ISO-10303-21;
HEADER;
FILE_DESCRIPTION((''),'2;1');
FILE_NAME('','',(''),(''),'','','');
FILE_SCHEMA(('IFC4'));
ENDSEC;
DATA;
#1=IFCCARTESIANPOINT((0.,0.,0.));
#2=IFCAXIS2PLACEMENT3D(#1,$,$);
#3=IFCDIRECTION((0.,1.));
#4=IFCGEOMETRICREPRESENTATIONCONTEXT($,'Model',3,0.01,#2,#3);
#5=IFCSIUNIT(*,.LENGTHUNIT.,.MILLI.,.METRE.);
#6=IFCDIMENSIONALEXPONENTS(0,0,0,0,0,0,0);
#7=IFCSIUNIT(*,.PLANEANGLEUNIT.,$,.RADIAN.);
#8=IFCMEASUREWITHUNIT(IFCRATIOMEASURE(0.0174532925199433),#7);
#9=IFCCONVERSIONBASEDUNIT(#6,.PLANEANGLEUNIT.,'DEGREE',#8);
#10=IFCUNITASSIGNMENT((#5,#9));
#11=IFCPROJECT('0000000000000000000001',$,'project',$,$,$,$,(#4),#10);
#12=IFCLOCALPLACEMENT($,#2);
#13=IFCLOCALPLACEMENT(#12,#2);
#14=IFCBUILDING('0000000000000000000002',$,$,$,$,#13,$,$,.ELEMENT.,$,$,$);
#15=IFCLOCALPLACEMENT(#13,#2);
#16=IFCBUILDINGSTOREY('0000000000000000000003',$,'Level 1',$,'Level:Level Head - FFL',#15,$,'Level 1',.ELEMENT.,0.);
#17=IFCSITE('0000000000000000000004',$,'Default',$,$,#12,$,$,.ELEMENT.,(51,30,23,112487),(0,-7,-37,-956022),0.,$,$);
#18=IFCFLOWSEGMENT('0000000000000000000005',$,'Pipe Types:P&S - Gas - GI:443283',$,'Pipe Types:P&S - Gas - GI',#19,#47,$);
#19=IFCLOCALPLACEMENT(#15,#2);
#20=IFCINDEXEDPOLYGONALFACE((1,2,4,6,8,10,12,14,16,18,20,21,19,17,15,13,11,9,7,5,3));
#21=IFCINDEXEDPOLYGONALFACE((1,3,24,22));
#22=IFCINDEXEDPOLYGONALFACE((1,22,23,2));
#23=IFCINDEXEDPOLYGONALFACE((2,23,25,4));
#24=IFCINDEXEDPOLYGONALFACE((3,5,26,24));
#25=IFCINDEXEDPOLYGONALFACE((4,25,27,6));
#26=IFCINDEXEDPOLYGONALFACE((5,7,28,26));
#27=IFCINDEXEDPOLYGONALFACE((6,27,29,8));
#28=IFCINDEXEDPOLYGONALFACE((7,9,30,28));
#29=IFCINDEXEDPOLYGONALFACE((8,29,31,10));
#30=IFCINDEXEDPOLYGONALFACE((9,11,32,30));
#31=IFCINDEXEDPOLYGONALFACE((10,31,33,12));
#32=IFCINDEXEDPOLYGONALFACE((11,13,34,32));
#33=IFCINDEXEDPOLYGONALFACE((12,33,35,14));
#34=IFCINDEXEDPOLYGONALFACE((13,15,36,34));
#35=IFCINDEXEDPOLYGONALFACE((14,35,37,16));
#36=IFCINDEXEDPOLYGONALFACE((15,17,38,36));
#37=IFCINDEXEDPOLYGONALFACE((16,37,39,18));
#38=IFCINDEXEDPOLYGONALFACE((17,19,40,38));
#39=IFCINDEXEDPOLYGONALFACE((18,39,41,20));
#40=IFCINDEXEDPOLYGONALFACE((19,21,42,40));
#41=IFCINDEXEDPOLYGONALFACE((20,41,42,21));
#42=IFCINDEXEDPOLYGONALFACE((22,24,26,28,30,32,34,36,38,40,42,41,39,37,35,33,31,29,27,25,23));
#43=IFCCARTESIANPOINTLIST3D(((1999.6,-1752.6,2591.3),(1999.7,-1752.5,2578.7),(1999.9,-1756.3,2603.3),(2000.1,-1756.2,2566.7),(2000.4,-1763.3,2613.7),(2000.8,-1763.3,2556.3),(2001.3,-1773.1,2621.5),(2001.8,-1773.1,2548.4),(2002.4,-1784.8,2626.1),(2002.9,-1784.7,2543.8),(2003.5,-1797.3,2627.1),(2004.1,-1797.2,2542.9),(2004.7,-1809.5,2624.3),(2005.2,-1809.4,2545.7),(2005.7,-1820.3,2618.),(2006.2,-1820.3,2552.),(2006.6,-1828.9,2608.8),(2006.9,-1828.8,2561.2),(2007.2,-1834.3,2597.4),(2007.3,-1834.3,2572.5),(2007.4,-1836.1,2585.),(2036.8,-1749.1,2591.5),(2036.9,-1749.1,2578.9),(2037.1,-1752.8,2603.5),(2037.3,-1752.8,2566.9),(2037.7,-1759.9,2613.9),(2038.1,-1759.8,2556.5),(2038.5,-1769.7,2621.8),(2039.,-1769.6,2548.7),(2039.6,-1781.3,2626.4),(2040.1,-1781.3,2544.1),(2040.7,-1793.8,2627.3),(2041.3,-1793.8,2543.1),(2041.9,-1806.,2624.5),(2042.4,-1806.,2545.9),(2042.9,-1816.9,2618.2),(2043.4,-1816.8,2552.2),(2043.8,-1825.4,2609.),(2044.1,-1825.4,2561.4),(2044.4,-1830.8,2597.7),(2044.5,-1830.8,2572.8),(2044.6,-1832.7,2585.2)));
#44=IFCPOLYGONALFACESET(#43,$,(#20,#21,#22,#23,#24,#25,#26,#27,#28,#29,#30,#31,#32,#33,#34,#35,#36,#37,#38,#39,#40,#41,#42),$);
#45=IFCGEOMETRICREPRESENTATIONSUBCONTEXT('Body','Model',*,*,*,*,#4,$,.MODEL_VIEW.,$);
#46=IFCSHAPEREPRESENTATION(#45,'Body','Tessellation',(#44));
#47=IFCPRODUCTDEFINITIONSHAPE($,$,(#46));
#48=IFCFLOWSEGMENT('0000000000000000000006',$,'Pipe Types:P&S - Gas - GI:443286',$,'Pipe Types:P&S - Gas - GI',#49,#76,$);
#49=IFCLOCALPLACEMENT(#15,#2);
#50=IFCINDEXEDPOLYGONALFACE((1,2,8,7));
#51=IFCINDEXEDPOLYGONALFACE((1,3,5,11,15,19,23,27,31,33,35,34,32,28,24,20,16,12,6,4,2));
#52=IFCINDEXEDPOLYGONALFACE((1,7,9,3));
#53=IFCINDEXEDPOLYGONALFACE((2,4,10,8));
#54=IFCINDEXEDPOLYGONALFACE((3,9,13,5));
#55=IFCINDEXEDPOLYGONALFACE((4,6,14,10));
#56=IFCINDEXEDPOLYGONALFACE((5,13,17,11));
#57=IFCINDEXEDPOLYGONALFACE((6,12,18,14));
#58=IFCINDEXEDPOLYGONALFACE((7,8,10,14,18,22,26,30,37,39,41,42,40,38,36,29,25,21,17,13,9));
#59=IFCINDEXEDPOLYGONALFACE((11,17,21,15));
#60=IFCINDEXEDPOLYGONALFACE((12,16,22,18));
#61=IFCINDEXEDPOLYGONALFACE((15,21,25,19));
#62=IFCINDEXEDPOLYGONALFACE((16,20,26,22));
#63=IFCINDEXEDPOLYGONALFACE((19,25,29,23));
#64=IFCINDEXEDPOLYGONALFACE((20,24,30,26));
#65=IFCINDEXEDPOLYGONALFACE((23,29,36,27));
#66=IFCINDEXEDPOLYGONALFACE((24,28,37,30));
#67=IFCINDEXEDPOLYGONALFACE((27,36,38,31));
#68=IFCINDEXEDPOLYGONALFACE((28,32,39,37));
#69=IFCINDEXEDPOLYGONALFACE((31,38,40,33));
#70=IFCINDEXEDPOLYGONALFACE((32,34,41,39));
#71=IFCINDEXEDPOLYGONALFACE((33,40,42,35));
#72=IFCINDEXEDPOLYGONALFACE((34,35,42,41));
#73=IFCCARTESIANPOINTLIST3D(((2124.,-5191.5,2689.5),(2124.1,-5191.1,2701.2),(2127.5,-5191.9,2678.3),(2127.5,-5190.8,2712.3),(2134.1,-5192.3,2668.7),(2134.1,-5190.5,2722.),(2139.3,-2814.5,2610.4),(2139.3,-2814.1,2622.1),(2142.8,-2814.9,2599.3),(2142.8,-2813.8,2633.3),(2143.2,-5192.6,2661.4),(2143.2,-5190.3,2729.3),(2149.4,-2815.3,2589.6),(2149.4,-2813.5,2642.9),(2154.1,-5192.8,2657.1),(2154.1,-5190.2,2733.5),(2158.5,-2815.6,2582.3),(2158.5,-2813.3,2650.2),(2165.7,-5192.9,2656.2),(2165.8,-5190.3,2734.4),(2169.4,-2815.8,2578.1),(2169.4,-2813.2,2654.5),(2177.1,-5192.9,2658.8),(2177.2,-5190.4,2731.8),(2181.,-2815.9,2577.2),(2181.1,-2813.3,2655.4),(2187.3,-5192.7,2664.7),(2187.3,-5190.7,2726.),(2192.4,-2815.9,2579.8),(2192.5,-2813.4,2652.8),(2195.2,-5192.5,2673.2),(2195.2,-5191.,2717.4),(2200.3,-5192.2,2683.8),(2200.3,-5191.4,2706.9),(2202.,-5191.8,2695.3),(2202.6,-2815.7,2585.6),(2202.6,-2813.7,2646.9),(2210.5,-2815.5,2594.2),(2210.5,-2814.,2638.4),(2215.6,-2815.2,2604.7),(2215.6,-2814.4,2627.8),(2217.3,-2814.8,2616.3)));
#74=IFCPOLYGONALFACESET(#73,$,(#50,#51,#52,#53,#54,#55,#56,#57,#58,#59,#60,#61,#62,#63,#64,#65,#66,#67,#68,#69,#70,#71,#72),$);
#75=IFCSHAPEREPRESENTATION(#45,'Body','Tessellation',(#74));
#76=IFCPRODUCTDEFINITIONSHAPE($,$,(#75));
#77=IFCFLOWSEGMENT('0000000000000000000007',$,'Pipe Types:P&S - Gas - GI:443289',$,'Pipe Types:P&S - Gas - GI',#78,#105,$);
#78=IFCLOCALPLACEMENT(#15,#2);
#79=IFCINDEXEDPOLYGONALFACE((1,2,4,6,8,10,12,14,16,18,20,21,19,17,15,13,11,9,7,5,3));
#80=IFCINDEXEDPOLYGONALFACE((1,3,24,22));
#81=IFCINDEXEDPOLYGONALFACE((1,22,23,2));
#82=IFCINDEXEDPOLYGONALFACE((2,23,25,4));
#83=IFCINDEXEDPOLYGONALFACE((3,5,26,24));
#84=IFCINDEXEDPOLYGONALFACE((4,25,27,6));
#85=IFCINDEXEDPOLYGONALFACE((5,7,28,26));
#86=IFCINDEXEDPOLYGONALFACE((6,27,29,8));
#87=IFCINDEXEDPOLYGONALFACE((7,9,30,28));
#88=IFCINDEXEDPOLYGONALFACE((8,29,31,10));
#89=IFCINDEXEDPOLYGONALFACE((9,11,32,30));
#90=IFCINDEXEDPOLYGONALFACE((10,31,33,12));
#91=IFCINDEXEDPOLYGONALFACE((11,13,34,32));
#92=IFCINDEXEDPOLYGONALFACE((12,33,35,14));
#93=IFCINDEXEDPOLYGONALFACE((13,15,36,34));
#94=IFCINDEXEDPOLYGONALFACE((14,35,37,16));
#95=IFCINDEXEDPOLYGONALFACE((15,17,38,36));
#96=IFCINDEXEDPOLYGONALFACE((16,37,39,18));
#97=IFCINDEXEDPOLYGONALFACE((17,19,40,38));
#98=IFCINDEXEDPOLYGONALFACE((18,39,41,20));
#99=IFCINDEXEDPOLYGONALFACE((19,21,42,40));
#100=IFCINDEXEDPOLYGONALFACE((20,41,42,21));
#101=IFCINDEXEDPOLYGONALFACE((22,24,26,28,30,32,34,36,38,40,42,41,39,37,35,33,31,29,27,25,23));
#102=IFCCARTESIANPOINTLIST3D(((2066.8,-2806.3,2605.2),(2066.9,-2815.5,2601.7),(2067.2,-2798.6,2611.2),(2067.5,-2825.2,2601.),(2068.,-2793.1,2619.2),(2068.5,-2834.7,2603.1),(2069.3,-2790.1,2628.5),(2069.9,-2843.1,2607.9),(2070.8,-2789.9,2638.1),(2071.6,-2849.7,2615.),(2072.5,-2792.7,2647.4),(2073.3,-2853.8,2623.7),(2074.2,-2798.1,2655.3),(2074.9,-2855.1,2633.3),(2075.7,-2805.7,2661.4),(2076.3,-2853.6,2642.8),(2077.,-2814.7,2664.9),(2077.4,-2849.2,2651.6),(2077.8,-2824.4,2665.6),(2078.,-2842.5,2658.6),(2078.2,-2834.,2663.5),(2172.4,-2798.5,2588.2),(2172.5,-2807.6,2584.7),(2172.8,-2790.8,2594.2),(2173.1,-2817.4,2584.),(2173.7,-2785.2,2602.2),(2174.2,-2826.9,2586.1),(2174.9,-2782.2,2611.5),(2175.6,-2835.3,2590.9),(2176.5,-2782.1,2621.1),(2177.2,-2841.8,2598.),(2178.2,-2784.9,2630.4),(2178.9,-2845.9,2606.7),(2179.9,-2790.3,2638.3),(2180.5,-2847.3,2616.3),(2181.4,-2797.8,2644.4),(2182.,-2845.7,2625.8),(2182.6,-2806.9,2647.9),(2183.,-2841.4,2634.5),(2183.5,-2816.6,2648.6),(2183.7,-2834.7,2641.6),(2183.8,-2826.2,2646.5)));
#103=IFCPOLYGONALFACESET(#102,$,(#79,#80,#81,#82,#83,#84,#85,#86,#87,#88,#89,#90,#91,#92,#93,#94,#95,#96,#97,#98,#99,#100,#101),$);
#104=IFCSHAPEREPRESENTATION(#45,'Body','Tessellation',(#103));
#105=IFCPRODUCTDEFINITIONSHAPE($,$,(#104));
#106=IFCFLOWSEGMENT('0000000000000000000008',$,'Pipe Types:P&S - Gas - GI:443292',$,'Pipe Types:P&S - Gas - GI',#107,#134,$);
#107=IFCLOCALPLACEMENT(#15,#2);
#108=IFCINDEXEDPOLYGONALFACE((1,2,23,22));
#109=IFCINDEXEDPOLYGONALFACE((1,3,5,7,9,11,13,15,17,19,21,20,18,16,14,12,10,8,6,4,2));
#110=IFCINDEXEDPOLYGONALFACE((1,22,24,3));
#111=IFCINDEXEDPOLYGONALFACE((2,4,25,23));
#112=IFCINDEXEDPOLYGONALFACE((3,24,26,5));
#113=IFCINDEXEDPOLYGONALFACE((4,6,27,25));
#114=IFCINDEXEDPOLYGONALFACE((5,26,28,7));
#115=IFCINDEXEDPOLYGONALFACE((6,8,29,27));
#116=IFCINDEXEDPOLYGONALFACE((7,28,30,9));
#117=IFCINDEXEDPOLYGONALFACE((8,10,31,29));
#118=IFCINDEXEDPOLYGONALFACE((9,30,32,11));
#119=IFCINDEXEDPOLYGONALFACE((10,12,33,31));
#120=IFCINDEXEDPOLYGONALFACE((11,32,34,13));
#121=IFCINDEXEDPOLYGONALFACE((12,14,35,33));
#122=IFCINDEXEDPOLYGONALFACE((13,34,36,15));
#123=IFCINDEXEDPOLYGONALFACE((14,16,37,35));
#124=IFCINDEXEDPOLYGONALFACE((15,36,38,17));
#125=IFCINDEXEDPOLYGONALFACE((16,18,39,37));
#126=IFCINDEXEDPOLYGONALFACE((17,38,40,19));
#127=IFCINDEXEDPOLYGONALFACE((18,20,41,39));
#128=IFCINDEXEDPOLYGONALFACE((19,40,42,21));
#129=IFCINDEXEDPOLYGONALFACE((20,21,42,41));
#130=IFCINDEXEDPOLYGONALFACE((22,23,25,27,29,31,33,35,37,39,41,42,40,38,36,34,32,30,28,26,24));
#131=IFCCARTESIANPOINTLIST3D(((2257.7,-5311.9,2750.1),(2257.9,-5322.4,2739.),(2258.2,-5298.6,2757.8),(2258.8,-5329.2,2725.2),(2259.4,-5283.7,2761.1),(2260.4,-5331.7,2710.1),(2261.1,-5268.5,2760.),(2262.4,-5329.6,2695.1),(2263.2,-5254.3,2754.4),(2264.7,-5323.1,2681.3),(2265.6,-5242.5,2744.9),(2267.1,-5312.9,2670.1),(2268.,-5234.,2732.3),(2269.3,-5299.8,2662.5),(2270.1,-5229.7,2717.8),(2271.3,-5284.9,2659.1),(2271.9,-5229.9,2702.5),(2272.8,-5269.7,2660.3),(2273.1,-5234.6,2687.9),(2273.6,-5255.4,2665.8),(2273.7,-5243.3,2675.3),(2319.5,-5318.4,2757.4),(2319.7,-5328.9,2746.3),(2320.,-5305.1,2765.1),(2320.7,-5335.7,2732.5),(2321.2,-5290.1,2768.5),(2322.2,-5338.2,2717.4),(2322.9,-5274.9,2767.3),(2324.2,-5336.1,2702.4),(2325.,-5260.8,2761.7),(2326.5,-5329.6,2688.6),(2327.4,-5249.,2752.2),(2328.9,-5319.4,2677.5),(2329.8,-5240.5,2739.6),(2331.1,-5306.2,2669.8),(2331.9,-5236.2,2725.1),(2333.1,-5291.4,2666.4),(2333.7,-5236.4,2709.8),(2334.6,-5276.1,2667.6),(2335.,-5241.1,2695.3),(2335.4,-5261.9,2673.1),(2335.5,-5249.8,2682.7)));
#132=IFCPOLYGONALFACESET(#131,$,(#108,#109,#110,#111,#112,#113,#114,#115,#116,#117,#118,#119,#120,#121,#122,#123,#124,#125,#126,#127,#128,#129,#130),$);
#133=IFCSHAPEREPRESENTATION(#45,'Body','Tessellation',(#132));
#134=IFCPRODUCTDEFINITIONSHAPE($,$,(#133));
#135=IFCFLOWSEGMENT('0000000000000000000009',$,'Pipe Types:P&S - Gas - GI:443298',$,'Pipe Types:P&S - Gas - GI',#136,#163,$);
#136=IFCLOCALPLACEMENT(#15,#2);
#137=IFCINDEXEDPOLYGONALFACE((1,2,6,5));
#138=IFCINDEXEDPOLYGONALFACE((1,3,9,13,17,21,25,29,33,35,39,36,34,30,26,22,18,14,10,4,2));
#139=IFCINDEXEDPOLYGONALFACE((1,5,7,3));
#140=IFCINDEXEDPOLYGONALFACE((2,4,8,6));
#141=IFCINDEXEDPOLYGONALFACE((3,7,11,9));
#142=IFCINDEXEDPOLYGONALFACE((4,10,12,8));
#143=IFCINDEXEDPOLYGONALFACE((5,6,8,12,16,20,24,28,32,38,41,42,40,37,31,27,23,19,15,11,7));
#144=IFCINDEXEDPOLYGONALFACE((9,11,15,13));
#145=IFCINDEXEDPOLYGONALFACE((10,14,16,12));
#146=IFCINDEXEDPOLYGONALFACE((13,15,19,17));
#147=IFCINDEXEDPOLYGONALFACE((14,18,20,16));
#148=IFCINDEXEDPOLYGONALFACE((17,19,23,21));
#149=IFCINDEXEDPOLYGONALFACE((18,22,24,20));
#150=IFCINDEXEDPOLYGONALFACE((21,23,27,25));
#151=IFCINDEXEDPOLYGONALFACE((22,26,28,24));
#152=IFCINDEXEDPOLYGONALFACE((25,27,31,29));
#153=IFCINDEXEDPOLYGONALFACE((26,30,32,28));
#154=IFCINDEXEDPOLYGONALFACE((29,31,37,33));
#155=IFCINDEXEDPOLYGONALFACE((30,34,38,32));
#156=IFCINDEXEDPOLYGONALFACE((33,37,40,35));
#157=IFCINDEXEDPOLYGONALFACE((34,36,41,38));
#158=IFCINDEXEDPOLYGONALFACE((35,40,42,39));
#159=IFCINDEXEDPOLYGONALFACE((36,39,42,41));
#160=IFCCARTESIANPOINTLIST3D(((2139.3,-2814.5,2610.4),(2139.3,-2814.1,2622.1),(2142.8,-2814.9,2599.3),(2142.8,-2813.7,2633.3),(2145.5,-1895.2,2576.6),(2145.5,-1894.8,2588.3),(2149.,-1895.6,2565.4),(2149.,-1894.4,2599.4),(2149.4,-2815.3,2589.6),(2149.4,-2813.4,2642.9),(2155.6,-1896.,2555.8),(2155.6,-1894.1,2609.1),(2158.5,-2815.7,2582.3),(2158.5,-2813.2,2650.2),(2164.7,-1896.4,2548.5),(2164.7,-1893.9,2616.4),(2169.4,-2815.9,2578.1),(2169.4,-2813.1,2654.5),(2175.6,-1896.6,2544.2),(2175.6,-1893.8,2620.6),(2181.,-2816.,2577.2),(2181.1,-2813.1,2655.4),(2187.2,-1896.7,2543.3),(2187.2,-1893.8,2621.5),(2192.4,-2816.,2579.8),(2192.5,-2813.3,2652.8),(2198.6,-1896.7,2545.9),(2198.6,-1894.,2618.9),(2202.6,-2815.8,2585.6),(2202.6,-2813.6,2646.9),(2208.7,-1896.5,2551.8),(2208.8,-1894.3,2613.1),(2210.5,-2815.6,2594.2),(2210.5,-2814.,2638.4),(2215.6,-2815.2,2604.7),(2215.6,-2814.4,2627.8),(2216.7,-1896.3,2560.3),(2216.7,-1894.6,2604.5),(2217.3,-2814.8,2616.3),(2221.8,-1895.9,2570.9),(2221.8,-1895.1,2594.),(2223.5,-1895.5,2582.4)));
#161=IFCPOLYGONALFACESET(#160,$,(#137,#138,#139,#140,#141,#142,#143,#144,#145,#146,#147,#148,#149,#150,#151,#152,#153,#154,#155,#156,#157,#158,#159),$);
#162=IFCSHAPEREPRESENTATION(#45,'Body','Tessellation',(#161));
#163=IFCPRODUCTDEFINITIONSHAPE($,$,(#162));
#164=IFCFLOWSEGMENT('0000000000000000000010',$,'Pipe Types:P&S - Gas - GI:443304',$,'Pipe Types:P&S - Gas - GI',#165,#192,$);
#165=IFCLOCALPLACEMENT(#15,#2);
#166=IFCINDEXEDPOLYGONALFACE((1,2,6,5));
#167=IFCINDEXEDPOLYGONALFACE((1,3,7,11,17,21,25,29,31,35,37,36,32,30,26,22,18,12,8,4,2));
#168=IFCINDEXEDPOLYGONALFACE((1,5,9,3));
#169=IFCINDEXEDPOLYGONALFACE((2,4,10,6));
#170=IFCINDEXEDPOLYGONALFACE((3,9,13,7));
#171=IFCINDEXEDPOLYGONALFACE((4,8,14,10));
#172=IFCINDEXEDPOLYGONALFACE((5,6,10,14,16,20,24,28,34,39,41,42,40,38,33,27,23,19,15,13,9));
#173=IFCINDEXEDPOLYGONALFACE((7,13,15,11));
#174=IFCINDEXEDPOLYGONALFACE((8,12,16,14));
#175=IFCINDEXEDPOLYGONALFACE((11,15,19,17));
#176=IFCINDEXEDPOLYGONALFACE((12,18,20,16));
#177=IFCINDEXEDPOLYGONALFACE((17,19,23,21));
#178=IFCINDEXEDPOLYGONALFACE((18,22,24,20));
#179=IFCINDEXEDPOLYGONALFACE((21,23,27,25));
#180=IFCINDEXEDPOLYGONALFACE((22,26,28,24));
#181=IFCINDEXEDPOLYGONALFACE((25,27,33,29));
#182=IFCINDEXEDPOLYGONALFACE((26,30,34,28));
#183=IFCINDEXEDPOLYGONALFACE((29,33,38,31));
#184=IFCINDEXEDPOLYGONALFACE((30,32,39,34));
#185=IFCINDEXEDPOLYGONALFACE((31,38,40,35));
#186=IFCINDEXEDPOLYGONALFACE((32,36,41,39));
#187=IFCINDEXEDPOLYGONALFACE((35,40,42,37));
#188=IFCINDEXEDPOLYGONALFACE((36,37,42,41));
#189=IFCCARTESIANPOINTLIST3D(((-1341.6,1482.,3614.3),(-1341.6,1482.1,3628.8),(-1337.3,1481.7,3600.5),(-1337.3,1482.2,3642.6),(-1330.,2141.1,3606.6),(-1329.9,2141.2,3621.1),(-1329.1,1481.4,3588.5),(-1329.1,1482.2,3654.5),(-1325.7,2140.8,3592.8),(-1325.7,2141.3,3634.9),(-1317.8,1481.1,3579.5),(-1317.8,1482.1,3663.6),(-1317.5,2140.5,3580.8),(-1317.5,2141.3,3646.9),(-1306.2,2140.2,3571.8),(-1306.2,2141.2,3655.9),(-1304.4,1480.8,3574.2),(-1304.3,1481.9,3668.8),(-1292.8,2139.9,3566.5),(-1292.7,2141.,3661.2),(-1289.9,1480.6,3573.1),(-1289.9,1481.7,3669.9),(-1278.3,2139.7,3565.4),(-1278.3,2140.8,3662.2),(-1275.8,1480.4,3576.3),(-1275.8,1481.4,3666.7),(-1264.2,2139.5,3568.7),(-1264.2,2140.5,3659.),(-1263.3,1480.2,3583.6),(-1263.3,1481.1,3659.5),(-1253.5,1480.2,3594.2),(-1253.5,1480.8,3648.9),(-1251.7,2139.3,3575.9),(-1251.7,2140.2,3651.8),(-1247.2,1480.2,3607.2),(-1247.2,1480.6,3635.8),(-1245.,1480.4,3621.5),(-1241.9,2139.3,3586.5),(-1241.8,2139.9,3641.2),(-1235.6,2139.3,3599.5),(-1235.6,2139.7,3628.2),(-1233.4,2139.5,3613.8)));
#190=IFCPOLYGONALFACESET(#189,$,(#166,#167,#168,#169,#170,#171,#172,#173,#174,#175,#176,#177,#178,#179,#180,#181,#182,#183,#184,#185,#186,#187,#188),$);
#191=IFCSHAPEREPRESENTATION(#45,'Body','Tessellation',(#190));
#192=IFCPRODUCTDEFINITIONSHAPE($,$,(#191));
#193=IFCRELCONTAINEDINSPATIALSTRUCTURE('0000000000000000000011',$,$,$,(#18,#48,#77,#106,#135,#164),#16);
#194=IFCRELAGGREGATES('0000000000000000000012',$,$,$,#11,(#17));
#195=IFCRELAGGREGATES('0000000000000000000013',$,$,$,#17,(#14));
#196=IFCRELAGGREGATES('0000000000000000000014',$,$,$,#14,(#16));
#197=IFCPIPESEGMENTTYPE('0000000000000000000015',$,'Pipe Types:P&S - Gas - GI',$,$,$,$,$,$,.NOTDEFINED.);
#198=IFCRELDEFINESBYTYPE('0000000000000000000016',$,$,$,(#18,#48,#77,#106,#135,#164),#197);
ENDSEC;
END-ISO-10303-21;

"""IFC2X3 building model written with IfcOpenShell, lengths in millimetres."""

from ifc_helpers import new_model, entity, si_unit, converted_unit, direction, frame, frame_2d, origin, origin_2d_with_axis, place, context, subcontext, project, spatial, circle, extrude, type_object, element, save


model = new_model("IFC2X3")

# Units and contexts
model_context = context("Model", 3, precision=0.01, world=origin(), true_north=direction((0.0, 1.0)))
body_context = subcontext(model_context, "Body", "Model", "MODEL_VIEW")
ifc_project = project(units=[si_unit("LENGTHUNIT", "METRE", prefix="MILLI"), converted_unit("PLANEANGLEUNIT", "DEGREE", entity("IfcRatioMeasure", 0.0174532925199433), si_unit("PLANEANGLEUNIT", "RADIAN"), dimensions=[0, 0, 0, 0, 0, 0, 0])], contexts=[model_context])

# Site, building, storey
site_placement = place(None, origin())
site = spatial("IfcSite", under=ifc_project, at=site_placement, Name="Default", CompositionType="ELEMENT", RefLatitude=(51, 30, 23, 112487), RefLongitude=(0, -7, -37, -956022), RefElevation=0.0)
building_placement = place(site_placement, origin())
building = spatial("IfcBuilding", under=site, at=building_placement, CompositionType="ELEMENT")
storey_placement = place(building_placement, origin())
storey = spatial("IfcBuildingStorey", under=building, at=storey_placement, Name="Level 1", ObjectType="Level:Level Head - FFL", LongName="Level 1", CompositionType="ELEMENT", Elevation=0.0)

# Flow segments
pipe_segment_type = type_object("IfcPipeSegmentType", Name="Pipe Types:P&S - Gas - GI", PredefinedType="NOTDEFINED")
flow_segment_1_placement = place(storey_placement, origin())
element("IfcFlowSegment", 1, at=flow_segment_1_placement, inside=storey, type_object=pipe_segment_type, Name="Pipe Types:P&S - Gas - GI:443283", ObjectType="Pipe Types:P&S - Gas - GI", context=body_context, shape_type="SweptSolid", body=[
    extrude(circle(Radius=42.2, at=origin_2d_with_axis()), frame((2003.5, -1794.1, 2585.0), z_axis=(0.99569, 0.09249, 0.006865), x_axis=(0.092492, -0.995713, 0.0)), (0.0, 0.0, 1.0), 37.4),
])
flow_segment_2_placement = place(storey_placement, origin())
element("IfcFlowSegment", 2, at=flow_segment_2_placement, inside=storey, type_object=pipe_segment_type, Name="Pipe Types:P&S - Gas - GI:443286", ObjectType="Pipe Types:P&S - Gas - GI", context=body_context, shape_type="SweptSolid", body=[
    extrude(circle(Radius=39.2, at=frame_2d((0.0, 0.0), x_axis=(1.0, 0.0))), frame((2162.8, -5191.6, 2695.3), z_axis=(0.00643, 0.999427, -0.033231), x_axis=(0.999979, -0.006434, 0.0)), (0.0, 0.0, 1.0), 2378.4),
])
flow_segment_3_placement = place(storey_placement, origin())
element("IfcFlowSegment", 3, at=flow_segment_3_placement, inside=storey, type_object=pipe_segment_type, Name="Pipe Types:P&S - Gas - GI:443289", ObjectType="Pipe Types:P&S - Gas - GI", context=body_context, shape_type="SweptSolid", body=[
    extrude(circle(Radius=32.8, at=frame_2d((0.0, 0.0), x_axis=(1.0, 0.0))), frame((2178.1, -2814.6, 2616.3), z_axis=(-0.984662, -0.07299, 0.158474), x_axis=(0.073924, -0.997264, 0.0)), (0.0, 0.0, 1.0), 107.3),
])
flow_segment_4_placement = place(storey_placement, origin())
element("IfcFlowSegment", 4, at=flow_segment_4_placement, inside=storey, type_object=pipe_segment_type, Name="Pipe Types:P&S - Gas - GI:443292", ObjectType="Pipe Types:P&S - Gas - GI", context=body_context, shape_type="SweptSolid", body=[
    extrude(circle(Radius=51.5, at=frame_2d((0.0, 0.0), x_axis=(1.0, 0.0))), frame((2327.5, -5286.9, 2717.4), z_axis=(-0.987779, 0.103283, -0.11673), x_axis=(-0.103994, -0.994578, 0.0)), (0.0, 0.0, 1.0), 62.6),
])
flow_segment_5_placement = place(storey_placement, origin())
element("IfcFlowSegment", 5, at=flow_segment_5_placement, inside=storey, type_object=pipe_segment_type, Name="Pipe Types:P&S - Gas - GI:443298", ObjectType="Pipe Types:P&S - Gas - GI", context=body_context, shape_type="SweptSolid", body=[
    extrude(circle(Radius=39.2, at=frame_2d((0.0, 0.0), x_axis=(1.0, 0.0))), frame((2184.3, -1895.2, 2582.4), z_axis=(-0.006722, -0.9993, 0.036814), x_axis=(0.999977, -0.006727, 0.0)), (0.0, 0.0, 1.0), 920.0),
])
flow_segment_6_placement = place(storey_placement, origin())
element("IfcFlowSegment", 6, at=flow_segment_6_placement, inside=storey, type_object=pipe_segment_type, Name="Pipe Types:P&S - Gas - GI:443304", ObjectType="Pipe Types:P&S - Gas - GI", context=body_context, shape_type="SweptSolid", body=[
    extrude(circle(Radius=48.5, at=frame_2d((0.0, 0.0), x_axis=(1.0, 0.0))), frame((-1282.0, 2140.3, 3613.8), z_axis=(-0.017599, -0.999777, 0.011644), x_axis=(0.999845, -0.017601, 0.0)), (0.0, 0.0, 1.0), 659.2),
])

save(model, "model.ifc")
